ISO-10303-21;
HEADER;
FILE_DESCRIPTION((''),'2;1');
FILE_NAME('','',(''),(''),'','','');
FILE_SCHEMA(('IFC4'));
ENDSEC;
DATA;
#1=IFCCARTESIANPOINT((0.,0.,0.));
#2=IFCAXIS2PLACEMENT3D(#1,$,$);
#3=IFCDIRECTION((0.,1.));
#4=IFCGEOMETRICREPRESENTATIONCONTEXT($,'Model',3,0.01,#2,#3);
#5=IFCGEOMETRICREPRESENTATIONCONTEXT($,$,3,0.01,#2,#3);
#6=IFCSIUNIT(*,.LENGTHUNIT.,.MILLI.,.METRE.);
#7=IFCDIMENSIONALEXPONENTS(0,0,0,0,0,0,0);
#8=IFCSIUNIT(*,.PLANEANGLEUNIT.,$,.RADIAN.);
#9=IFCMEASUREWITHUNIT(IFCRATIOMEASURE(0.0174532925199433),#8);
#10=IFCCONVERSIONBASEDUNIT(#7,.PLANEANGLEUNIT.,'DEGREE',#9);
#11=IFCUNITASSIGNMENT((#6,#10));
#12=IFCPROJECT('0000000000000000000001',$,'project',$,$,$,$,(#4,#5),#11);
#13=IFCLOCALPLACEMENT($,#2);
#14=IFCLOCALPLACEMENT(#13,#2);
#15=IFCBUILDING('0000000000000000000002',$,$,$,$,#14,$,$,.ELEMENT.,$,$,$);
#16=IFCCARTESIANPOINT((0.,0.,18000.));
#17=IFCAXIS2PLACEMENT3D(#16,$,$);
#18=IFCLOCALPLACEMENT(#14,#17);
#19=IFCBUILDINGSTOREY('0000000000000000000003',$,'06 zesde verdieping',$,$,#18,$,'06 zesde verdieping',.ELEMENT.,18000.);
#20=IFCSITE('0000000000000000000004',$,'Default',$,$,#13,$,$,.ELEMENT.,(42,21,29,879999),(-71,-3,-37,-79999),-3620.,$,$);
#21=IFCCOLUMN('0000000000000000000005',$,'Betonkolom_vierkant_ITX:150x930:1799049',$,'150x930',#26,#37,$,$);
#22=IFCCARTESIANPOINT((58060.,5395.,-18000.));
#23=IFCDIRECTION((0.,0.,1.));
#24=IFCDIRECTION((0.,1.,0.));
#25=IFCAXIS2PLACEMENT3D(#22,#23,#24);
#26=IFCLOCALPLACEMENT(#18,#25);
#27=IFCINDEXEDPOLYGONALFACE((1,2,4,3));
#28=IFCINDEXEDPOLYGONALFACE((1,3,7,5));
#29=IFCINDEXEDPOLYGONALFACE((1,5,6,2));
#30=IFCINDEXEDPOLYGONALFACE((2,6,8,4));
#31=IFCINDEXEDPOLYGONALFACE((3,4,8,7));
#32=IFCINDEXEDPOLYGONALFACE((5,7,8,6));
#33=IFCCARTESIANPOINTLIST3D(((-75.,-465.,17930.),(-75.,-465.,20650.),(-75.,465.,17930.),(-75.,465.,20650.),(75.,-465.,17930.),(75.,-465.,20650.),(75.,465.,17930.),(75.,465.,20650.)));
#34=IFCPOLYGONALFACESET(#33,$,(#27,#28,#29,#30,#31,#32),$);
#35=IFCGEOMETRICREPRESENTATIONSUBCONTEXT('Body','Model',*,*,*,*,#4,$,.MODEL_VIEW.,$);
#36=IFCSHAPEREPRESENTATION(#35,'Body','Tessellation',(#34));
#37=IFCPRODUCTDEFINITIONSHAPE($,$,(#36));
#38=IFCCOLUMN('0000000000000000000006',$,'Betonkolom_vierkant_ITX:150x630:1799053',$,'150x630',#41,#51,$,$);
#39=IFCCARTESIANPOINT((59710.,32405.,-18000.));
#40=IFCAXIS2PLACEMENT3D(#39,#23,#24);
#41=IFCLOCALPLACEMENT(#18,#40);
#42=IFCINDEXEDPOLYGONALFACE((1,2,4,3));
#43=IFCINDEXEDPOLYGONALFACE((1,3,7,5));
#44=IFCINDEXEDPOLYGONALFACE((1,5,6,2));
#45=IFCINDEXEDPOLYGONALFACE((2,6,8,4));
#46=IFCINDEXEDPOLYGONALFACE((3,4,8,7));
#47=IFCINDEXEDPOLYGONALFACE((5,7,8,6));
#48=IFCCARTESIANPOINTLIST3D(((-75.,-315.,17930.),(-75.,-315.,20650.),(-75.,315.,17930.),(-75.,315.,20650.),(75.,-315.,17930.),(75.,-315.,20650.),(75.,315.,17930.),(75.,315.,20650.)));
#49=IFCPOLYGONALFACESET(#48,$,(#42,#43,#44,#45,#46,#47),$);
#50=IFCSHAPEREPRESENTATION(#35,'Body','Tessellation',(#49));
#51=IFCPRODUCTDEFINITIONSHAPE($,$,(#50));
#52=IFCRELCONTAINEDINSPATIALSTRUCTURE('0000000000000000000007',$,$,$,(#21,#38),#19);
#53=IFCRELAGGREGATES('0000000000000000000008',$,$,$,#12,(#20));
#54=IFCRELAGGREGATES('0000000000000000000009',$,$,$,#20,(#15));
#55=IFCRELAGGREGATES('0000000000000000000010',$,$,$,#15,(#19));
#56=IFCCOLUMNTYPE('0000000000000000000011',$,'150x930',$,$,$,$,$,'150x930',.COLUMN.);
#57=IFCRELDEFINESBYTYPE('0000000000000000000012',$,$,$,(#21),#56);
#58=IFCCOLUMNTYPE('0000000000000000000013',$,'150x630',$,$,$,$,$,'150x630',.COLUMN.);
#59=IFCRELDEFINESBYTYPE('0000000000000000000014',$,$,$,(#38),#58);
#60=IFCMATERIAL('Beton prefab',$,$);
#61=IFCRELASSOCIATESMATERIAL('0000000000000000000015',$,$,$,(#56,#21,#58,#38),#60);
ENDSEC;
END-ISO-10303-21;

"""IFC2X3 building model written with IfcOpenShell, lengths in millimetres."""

from ifc_helpers import new_model, entity, si_unit, converted_unit, direction, frame, origin, origin_2d_with_axis, place, context, subcontext, project, spatial, rectangle, extrude, source, transform, mapped, material, type_object, type_shapes, element, save


model = new_model("IFC2X3")

# Units and contexts
model_context = context("Model", 3, precision=0.01, world=origin(), true_north=direction((0.0, 1.0)))
context_of_model = context(None, 3, precision=0.01, world=origin(), true_north=direction((0.0, 1.0)))
body_context = subcontext(model_context, "Body", "Model", "MODEL_VIEW")
ifc_project = project(units=[si_unit("LENGTHUNIT", "METRE", prefix="MILLI"), converted_unit("PLANEANGLEUNIT", "DEGREE", entity("IfcRatioMeasure", 0.0174532925199433), si_unit("PLANEANGLEUNIT", "RADIAN"), dimensions=[0, 0, 0, 0, 0, 0, 0])], contexts=[model_context, context_of_model])

# Site, building, storey
site_placement = place(None, origin())
site = spatial("IfcSite", under=ifc_project, at=site_placement, Name="Default", CompositionType="ELEMENT", RefLatitude=(42, 21, 29, 879999), RefLongitude=(-71, -3, -37, -79999), RefElevation=-3620.0)
building_placement = place(site_placement, origin())
building = spatial("IfcBuilding", under=site, at=building_placement, CompositionType="ELEMENT")
storey_placement = place(building_placement, frame((0.0, 0.0, 18000.0)))
storey = spatial("IfcBuildingStorey", under=building, at=storey_placement, Name="06 zesde verdieping", LongName="06 zesde verdieping", CompositionType="ELEMENT", Elevation=18000.0)

# Columns
ifc_material_1 = material(Name="Beton prefab")
column_type_1 = type_object("IfcColumnType", Name="150x930", ElementType="150x930", PredefinedType="COLUMN", material=ifc_material_1)
shared_shape_1 = source(origin(), body_context, "Body", "SweptSolid", [
    extrude(rectangle(XDim=930.0, YDim=150.0, at=origin_2d_with_axis()), frame((0.0, 0.0, 17930.0), z_axis=(0.0, 0.0, 1.0), x_axis=(0.0, -1.0, 0.0)), (0.0, 0.0, 1.0), 2720.0),
])
type_shapes(column_type_1, [shared_shape_1])
column_1_placement = place(storey_placement, frame((58060.0, 5395.0, -18000.0), z_axis=(0.0, 0.0, 1.0), x_axis=(0.0, 1.0, 0.0)))
element("IfcColumn", 1, at=column_1_placement, inside=storey, type_object=column_type_1, material=ifc_material_1, Name="Betonkolom_vierkant_ITX:150x930:1799049", ObjectType="150x930", context=body_context, shape_type="MappedRepresentation", body=[
    mapped(shared_shape_1, transform((0.0, 0.0, 0.0), scale=1.0)),
])
column_type_2 = type_object("IfcColumnType", Name="150x630", ElementType="150x630", PredefinedType="COLUMN", material=ifc_material_1)
shared_shape_2 = source(origin(), body_context, "Body", "SweptSolid", [
    extrude(rectangle(XDim=630.0, YDim=150.0, at=origin_2d_with_axis()), frame((0.0, 0.0, 17930.0), z_axis=(0.0, 0.0, 1.0), x_axis=(0.0, -1.0, 0.0)), (0.0, 0.0, 1.0), 2720.0),
])
type_shapes(column_type_2, [shared_shape_2])
column_2_placement = place(storey_placement, frame((59710.0, 32405.0, -18000.0), z_axis=(0.0, 0.0, 1.0), x_axis=(0.0, 1.0, 0.0)))
element("IfcColumn", 2, at=column_2_placement, inside=storey, type_object=column_type_2, material=ifc_material_1, Name="Betonkolom_vierkant_ITX:150x630:1799053", ObjectType="150x630", context=body_context, shape_type="MappedRepresentation", body=[
    mapped(shared_shape_2, transform((0.0, 0.0, 0.0), scale=1.0)),
])

save(model, "model.ifc")
